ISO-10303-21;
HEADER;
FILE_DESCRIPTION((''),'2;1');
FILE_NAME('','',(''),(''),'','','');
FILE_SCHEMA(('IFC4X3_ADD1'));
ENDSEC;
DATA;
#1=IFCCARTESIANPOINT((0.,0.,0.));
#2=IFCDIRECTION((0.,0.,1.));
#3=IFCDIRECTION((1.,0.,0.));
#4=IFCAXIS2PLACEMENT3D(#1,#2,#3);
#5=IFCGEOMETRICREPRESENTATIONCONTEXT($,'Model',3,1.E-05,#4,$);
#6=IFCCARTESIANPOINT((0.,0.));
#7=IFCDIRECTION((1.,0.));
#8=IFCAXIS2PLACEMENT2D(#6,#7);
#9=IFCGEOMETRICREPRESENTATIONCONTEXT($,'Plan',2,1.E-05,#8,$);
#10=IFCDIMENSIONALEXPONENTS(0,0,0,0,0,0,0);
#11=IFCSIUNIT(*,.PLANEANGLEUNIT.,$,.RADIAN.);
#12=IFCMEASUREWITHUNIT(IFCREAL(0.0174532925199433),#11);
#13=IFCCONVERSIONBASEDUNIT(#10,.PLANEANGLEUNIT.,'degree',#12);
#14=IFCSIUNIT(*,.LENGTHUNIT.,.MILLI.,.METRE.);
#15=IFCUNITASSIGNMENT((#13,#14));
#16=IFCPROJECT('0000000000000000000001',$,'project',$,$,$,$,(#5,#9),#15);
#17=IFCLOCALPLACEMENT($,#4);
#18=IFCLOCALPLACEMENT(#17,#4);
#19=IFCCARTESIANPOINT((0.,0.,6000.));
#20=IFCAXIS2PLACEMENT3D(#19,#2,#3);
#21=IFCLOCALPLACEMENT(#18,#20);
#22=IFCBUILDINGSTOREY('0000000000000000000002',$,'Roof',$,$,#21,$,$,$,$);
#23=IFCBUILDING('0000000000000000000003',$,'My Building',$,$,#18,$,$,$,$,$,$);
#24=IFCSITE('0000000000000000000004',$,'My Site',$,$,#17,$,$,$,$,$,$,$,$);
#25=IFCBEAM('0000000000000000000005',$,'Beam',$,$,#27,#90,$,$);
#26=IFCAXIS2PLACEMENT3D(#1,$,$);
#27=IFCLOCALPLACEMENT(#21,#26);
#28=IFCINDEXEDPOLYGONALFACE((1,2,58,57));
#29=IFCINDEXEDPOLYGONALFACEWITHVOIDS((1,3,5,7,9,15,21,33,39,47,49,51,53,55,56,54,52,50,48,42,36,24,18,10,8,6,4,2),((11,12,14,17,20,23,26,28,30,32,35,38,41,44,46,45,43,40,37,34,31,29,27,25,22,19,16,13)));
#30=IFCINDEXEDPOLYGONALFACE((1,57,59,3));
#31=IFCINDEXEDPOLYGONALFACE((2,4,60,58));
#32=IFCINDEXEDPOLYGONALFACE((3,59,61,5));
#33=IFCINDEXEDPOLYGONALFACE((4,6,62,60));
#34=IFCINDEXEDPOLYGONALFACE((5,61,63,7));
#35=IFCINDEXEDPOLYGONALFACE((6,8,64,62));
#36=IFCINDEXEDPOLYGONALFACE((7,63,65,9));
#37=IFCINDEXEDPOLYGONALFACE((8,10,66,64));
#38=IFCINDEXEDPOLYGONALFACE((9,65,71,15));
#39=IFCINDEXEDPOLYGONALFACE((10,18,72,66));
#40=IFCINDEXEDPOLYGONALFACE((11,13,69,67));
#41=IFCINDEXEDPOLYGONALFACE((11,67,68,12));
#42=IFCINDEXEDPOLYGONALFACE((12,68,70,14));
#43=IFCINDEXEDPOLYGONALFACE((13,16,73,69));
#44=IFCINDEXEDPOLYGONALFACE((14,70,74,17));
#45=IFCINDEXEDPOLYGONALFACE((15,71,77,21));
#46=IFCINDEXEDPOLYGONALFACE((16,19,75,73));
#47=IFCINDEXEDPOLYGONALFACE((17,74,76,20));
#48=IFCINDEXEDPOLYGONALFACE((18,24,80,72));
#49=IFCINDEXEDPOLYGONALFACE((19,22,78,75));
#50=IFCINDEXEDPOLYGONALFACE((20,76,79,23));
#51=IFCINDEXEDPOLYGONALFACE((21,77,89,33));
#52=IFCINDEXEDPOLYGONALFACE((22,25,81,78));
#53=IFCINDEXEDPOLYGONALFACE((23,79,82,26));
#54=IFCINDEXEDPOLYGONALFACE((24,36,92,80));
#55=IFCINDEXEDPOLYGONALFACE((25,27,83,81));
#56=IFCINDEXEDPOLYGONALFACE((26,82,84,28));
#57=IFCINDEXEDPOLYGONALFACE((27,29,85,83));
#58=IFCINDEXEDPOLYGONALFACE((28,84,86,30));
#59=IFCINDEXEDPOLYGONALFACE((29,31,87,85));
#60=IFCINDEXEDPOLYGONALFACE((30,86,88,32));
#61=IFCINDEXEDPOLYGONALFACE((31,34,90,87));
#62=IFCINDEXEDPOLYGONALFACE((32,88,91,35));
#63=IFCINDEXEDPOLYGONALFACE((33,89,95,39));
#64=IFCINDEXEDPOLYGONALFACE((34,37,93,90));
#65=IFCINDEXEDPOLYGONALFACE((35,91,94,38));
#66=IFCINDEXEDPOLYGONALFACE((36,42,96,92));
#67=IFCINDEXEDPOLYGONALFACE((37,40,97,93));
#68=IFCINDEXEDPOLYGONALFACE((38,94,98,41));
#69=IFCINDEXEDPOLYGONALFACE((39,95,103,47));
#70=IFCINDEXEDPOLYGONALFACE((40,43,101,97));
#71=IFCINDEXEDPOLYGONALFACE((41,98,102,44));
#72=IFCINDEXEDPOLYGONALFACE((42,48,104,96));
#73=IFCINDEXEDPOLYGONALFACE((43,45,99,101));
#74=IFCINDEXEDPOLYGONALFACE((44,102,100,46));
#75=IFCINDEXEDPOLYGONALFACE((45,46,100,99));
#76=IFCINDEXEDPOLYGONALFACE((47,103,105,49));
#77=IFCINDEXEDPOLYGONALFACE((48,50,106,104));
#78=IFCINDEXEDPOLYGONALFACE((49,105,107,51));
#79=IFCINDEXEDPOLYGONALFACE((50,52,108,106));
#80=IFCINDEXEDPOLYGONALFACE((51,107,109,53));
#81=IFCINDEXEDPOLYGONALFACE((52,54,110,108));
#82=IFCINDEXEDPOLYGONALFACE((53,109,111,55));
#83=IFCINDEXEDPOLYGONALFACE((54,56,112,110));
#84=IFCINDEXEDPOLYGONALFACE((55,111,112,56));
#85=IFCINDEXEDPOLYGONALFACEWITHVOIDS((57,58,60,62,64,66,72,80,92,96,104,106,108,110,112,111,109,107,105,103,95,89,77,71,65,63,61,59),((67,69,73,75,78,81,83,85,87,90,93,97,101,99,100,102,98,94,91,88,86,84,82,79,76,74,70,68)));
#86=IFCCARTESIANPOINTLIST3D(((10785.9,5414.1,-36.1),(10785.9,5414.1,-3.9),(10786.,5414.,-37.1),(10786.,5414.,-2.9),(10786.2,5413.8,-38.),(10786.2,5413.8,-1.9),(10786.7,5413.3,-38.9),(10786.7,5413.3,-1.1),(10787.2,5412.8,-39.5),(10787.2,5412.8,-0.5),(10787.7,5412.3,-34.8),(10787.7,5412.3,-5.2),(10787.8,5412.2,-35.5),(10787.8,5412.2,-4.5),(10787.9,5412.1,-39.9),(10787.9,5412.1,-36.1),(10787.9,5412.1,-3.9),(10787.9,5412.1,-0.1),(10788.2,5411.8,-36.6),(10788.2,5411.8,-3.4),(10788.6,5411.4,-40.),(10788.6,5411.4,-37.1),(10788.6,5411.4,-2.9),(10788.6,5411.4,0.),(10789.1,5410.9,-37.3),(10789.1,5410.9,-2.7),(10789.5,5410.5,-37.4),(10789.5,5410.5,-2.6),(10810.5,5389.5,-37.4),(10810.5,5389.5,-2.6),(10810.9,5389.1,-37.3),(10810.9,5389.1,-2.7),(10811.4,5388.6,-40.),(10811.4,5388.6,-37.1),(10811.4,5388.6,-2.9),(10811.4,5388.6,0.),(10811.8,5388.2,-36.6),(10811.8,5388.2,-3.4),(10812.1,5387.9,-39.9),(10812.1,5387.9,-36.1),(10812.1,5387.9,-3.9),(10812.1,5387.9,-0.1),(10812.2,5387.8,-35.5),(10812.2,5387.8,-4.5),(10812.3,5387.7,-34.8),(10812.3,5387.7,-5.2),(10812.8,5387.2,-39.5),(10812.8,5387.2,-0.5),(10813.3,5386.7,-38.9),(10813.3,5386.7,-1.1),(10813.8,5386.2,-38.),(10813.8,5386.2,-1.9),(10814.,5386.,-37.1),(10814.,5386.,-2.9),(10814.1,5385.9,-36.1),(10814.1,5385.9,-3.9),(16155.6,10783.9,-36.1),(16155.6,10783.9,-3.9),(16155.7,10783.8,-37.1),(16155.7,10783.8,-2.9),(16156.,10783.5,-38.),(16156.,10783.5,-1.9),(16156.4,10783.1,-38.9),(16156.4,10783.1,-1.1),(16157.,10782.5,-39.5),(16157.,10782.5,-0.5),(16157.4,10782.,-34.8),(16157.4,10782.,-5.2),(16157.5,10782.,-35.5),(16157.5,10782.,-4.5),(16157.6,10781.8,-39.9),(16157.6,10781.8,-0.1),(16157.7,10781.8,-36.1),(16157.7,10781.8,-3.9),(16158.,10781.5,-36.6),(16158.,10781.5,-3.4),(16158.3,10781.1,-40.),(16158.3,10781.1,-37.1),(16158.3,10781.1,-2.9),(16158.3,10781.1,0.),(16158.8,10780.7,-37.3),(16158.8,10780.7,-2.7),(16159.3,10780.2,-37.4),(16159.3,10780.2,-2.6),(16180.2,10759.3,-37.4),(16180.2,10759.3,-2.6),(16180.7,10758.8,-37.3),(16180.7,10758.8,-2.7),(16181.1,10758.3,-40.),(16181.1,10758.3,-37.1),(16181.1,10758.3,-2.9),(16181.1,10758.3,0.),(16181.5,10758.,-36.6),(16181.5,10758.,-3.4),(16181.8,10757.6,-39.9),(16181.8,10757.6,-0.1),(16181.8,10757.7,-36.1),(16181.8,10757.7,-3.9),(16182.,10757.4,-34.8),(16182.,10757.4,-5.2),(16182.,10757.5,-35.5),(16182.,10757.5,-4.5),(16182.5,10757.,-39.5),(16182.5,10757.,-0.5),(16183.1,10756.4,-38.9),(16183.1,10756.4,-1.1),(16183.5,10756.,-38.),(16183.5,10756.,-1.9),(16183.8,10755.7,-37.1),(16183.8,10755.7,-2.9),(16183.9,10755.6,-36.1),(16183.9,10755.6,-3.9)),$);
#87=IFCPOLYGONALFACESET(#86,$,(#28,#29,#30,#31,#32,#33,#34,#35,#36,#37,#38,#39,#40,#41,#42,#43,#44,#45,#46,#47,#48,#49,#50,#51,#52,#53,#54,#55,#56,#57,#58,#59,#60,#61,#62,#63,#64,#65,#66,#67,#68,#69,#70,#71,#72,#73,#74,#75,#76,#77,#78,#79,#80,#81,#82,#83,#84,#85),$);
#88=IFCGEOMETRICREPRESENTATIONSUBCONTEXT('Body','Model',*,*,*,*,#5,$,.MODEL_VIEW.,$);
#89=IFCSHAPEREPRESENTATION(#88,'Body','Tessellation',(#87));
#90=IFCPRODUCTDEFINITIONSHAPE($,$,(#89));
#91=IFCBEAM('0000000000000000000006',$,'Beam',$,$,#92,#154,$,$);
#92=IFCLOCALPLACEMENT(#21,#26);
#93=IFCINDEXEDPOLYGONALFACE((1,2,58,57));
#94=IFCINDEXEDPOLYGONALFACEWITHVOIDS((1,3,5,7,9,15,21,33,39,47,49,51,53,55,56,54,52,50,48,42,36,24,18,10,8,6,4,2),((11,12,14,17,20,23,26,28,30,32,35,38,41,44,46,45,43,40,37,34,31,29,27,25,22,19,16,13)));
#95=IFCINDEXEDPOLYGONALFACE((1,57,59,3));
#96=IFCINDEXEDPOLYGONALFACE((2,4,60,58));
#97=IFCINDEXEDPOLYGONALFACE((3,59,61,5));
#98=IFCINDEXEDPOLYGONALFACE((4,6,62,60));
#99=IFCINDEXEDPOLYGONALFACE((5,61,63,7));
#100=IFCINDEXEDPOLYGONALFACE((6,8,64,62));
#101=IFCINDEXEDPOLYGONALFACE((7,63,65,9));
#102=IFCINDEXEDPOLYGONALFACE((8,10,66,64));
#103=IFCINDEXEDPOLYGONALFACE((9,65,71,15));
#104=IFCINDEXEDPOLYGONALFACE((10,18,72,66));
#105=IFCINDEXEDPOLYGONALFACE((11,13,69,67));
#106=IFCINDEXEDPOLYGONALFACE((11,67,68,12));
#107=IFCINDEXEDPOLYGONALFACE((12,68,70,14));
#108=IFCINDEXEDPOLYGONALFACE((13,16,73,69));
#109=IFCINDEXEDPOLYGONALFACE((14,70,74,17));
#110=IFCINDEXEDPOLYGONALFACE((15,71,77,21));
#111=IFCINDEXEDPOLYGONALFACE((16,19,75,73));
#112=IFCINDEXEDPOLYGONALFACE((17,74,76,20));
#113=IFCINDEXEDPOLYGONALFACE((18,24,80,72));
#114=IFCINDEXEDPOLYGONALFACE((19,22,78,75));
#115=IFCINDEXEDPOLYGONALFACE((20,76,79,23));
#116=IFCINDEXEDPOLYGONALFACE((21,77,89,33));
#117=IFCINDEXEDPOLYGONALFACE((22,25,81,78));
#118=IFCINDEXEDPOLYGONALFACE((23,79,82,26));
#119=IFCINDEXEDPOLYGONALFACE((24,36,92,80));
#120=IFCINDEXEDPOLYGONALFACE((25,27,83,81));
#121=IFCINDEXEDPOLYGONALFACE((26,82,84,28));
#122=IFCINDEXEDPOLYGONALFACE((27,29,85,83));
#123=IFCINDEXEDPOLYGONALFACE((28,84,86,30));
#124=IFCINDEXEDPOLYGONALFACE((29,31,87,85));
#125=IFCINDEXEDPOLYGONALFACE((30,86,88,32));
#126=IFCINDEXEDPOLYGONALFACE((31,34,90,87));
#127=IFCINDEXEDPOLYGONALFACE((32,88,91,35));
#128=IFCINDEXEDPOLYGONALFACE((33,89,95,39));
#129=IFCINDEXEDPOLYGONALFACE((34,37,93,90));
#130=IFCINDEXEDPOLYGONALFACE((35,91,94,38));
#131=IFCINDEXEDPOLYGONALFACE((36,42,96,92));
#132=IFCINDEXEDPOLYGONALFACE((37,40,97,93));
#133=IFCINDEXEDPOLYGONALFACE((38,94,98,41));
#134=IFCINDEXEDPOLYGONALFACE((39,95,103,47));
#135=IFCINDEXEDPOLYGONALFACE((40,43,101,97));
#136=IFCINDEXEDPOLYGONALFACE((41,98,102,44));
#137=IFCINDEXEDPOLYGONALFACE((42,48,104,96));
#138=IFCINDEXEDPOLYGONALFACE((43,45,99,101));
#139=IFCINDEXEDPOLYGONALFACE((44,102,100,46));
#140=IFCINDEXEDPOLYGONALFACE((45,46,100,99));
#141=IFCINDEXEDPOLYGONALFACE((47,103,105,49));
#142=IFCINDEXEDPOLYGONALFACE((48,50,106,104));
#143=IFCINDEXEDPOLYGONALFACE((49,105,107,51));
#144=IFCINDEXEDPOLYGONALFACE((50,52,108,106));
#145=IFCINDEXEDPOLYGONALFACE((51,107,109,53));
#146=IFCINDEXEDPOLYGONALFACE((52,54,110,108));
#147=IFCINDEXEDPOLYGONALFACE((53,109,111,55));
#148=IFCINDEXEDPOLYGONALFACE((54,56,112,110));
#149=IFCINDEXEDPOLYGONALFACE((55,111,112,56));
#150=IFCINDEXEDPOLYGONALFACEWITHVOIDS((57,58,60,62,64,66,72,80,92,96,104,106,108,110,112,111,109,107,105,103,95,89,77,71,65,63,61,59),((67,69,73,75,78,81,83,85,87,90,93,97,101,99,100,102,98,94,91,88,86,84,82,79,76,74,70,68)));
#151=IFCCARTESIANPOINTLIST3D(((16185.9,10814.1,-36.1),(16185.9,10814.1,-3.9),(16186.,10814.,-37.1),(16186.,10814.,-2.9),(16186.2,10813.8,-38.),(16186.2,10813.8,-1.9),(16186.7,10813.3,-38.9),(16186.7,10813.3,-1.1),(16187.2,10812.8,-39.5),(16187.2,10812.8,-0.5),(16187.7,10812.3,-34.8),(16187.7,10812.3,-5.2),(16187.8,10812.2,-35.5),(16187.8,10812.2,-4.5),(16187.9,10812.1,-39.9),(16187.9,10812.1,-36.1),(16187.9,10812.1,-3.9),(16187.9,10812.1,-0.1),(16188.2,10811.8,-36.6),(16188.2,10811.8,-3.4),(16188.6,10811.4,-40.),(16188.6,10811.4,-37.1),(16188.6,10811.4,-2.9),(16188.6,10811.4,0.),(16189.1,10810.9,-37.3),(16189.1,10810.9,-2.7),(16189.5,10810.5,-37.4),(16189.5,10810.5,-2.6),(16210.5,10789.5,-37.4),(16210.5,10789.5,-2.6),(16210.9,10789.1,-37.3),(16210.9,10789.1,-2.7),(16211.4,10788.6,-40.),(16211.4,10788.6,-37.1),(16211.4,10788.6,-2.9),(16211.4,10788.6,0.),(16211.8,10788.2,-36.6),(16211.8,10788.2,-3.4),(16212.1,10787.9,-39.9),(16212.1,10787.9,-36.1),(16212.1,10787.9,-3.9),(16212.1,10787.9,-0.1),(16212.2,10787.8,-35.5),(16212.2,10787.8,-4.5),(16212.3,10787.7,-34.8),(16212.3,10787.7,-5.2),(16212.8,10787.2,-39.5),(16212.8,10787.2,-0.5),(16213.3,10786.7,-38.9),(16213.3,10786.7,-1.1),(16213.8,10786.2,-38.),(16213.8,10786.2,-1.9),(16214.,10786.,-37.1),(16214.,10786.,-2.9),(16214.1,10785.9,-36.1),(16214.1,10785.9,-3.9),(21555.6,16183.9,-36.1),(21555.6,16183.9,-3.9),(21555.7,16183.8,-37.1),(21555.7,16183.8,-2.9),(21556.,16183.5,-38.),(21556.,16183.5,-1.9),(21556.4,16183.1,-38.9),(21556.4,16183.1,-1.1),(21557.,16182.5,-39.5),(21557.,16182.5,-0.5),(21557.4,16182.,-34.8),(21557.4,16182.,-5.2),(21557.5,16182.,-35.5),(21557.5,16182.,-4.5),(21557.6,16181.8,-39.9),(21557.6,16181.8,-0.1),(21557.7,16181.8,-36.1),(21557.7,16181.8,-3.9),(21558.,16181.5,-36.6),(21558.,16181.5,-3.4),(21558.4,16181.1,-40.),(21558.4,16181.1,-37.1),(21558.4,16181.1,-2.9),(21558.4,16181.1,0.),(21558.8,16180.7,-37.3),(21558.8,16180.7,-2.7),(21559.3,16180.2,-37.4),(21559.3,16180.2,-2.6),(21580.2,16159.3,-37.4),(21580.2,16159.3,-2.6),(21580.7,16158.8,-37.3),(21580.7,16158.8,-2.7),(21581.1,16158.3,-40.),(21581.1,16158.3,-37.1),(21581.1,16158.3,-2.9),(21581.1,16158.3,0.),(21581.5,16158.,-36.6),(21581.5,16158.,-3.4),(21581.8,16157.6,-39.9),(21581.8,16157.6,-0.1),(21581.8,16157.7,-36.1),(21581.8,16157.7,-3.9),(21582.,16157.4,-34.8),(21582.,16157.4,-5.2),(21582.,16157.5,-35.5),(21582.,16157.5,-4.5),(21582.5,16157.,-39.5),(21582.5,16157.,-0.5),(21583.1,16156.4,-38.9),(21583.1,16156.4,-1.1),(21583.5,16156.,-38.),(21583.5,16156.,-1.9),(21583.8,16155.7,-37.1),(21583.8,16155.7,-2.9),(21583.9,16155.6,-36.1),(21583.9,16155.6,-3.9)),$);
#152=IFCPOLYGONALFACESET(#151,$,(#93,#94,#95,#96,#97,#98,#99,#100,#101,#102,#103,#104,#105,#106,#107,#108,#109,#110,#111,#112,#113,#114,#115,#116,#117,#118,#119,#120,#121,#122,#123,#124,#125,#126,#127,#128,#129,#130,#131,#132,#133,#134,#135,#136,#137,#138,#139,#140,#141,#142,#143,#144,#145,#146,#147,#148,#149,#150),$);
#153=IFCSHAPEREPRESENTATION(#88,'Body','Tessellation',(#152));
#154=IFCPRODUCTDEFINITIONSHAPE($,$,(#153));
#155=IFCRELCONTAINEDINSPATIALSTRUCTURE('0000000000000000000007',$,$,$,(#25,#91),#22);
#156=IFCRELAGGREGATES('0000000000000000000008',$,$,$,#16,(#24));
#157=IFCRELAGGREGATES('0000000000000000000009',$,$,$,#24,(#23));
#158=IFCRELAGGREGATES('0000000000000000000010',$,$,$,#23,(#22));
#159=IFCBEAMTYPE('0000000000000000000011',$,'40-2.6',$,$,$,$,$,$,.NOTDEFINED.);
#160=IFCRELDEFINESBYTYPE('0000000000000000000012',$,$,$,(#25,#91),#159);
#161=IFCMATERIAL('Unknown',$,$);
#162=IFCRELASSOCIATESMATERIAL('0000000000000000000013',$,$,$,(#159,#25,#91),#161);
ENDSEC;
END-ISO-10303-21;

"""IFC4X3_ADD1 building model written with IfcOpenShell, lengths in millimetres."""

from ifc_helpers import new_model, entity, si_unit, converted_unit, frame, origin_with_axes, origin_2d_with_axis, place, context, subcontext, project, spatial, hollow_rectangle, extrude, material, material_profile, profile_set, profile_usage, type_object, element, save


model = new_model("IFC4X3_ADD1")

# Units and contexts
model_context = context("Model", 3, precision=1e-05, world=origin_with_axes())
plan_context = context("Plan", 2, precision=1e-05, world=origin_2d_with_axis())
body_context = subcontext(model_context, "Body", "Model", "MODEL_VIEW")
ifc_project = project(units=[converted_unit("PLANEANGLEUNIT", "degree", entity("IfcReal", 0.0174532925199433), si_unit("PLANEANGLEUNIT", "RADIAN"), dimensions=[0, 0, 0, 0, 0, 0, 0]), si_unit("LENGTHUNIT", "METRE", prefix="MILLI")], contexts=[model_context, plan_context])

# Site, building, storey
site_placement = place(None, origin_with_axes())
site = spatial("IfcSite", under=ifc_project, at=site_placement, Name="My Site")
building_placement = place(site_placement, origin_with_axes())
building = spatial("IfcBuilding", under=site, at=building_placement, Name="My Building")
storey_placement = place(building_placement, frame((0.0, 0.0, 6000.0), z_axis=(0.0, 0.0, 1.0), x_axis=(1.0, 0.0, 0.0)))
storey = spatial("IfcBuildingStorey", under=building, at=storey_placement, Name="Roof")

# Beams
ifc_material = material(Name="Unknown")
ifc_material_profile_1 = material_profile(ifc_material, hollow_rectangle(XDim=40.0, YDim=40.0, WallThickness=2.6, InnerFilletRadius=2.6, OuterFilletRadius=3.9))
ifc_profile_set_1 = profile_set([ifc_material_profile_1])
beam_type_1 = type_object("IfcBeamType", Name="40-2.6", PredefinedType="NOTDEFINED", material=ifc_profile_set_1)
ifc_profile_usage_1 = profile_usage(ifc_profile_set_1, cardinal=8)
beam_1_placement = place(storey_placement, frame((10800.0, 5400.0, 0.0), z_axis=(0.707107, 0.707107, 0.0), x_axis=(-0.707107, 0.707107, 0.0)))
element("IfcBeam", 1, at=beam_1_placement, inside=storey, type_object=beam_type_1, material=ifc_profile_usage_1, Name="Beam", context=body_context, shape_type="SweptSolid", body=[
    extrude(hollow_rectangle(XDim=40.0, YDim=40.0, WallThickness=2.6, InnerFilletRadius=2.6, OuterFilletRadius=3.9), frame((0.0, -20.0, 0.0), z_axis=(0.0, 0.0, 1.0), x_axis=(1.0, 0.0, 0.0)), (0.0, 0.0, 1.0), 7594.0),
])
ifc_profile_usage_2 = profile_usage(ifc_profile_set_1, cardinal=8)
beam_2_placement = place(storey_placement, frame((16200.0, 10800.0, 0.0), z_axis=(0.707107, 0.707107, 0.0), x_axis=(-0.707107, 0.707107, 0.0)))
element("IfcBeam", 2, at=beam_2_placement, inside=storey, type_object=beam_type_1, material=ifc_profile_usage_2, Name="Beam", context=body_context, shape_type="SweptSolid", body=[
    extrude(hollow_rectangle(XDim=40.0, YDim=40.0, WallThickness=2.6, InnerFilletRadius=2.6, OuterFilletRadius=3.9), frame((0.0, -20.0, 0.0), z_axis=(0.0, 0.0, 1.0), x_axis=(1.0, 0.0, 0.0)), (0.0, 0.0, 1.0), 7594.0),
])

save(model, "model.ifc")
